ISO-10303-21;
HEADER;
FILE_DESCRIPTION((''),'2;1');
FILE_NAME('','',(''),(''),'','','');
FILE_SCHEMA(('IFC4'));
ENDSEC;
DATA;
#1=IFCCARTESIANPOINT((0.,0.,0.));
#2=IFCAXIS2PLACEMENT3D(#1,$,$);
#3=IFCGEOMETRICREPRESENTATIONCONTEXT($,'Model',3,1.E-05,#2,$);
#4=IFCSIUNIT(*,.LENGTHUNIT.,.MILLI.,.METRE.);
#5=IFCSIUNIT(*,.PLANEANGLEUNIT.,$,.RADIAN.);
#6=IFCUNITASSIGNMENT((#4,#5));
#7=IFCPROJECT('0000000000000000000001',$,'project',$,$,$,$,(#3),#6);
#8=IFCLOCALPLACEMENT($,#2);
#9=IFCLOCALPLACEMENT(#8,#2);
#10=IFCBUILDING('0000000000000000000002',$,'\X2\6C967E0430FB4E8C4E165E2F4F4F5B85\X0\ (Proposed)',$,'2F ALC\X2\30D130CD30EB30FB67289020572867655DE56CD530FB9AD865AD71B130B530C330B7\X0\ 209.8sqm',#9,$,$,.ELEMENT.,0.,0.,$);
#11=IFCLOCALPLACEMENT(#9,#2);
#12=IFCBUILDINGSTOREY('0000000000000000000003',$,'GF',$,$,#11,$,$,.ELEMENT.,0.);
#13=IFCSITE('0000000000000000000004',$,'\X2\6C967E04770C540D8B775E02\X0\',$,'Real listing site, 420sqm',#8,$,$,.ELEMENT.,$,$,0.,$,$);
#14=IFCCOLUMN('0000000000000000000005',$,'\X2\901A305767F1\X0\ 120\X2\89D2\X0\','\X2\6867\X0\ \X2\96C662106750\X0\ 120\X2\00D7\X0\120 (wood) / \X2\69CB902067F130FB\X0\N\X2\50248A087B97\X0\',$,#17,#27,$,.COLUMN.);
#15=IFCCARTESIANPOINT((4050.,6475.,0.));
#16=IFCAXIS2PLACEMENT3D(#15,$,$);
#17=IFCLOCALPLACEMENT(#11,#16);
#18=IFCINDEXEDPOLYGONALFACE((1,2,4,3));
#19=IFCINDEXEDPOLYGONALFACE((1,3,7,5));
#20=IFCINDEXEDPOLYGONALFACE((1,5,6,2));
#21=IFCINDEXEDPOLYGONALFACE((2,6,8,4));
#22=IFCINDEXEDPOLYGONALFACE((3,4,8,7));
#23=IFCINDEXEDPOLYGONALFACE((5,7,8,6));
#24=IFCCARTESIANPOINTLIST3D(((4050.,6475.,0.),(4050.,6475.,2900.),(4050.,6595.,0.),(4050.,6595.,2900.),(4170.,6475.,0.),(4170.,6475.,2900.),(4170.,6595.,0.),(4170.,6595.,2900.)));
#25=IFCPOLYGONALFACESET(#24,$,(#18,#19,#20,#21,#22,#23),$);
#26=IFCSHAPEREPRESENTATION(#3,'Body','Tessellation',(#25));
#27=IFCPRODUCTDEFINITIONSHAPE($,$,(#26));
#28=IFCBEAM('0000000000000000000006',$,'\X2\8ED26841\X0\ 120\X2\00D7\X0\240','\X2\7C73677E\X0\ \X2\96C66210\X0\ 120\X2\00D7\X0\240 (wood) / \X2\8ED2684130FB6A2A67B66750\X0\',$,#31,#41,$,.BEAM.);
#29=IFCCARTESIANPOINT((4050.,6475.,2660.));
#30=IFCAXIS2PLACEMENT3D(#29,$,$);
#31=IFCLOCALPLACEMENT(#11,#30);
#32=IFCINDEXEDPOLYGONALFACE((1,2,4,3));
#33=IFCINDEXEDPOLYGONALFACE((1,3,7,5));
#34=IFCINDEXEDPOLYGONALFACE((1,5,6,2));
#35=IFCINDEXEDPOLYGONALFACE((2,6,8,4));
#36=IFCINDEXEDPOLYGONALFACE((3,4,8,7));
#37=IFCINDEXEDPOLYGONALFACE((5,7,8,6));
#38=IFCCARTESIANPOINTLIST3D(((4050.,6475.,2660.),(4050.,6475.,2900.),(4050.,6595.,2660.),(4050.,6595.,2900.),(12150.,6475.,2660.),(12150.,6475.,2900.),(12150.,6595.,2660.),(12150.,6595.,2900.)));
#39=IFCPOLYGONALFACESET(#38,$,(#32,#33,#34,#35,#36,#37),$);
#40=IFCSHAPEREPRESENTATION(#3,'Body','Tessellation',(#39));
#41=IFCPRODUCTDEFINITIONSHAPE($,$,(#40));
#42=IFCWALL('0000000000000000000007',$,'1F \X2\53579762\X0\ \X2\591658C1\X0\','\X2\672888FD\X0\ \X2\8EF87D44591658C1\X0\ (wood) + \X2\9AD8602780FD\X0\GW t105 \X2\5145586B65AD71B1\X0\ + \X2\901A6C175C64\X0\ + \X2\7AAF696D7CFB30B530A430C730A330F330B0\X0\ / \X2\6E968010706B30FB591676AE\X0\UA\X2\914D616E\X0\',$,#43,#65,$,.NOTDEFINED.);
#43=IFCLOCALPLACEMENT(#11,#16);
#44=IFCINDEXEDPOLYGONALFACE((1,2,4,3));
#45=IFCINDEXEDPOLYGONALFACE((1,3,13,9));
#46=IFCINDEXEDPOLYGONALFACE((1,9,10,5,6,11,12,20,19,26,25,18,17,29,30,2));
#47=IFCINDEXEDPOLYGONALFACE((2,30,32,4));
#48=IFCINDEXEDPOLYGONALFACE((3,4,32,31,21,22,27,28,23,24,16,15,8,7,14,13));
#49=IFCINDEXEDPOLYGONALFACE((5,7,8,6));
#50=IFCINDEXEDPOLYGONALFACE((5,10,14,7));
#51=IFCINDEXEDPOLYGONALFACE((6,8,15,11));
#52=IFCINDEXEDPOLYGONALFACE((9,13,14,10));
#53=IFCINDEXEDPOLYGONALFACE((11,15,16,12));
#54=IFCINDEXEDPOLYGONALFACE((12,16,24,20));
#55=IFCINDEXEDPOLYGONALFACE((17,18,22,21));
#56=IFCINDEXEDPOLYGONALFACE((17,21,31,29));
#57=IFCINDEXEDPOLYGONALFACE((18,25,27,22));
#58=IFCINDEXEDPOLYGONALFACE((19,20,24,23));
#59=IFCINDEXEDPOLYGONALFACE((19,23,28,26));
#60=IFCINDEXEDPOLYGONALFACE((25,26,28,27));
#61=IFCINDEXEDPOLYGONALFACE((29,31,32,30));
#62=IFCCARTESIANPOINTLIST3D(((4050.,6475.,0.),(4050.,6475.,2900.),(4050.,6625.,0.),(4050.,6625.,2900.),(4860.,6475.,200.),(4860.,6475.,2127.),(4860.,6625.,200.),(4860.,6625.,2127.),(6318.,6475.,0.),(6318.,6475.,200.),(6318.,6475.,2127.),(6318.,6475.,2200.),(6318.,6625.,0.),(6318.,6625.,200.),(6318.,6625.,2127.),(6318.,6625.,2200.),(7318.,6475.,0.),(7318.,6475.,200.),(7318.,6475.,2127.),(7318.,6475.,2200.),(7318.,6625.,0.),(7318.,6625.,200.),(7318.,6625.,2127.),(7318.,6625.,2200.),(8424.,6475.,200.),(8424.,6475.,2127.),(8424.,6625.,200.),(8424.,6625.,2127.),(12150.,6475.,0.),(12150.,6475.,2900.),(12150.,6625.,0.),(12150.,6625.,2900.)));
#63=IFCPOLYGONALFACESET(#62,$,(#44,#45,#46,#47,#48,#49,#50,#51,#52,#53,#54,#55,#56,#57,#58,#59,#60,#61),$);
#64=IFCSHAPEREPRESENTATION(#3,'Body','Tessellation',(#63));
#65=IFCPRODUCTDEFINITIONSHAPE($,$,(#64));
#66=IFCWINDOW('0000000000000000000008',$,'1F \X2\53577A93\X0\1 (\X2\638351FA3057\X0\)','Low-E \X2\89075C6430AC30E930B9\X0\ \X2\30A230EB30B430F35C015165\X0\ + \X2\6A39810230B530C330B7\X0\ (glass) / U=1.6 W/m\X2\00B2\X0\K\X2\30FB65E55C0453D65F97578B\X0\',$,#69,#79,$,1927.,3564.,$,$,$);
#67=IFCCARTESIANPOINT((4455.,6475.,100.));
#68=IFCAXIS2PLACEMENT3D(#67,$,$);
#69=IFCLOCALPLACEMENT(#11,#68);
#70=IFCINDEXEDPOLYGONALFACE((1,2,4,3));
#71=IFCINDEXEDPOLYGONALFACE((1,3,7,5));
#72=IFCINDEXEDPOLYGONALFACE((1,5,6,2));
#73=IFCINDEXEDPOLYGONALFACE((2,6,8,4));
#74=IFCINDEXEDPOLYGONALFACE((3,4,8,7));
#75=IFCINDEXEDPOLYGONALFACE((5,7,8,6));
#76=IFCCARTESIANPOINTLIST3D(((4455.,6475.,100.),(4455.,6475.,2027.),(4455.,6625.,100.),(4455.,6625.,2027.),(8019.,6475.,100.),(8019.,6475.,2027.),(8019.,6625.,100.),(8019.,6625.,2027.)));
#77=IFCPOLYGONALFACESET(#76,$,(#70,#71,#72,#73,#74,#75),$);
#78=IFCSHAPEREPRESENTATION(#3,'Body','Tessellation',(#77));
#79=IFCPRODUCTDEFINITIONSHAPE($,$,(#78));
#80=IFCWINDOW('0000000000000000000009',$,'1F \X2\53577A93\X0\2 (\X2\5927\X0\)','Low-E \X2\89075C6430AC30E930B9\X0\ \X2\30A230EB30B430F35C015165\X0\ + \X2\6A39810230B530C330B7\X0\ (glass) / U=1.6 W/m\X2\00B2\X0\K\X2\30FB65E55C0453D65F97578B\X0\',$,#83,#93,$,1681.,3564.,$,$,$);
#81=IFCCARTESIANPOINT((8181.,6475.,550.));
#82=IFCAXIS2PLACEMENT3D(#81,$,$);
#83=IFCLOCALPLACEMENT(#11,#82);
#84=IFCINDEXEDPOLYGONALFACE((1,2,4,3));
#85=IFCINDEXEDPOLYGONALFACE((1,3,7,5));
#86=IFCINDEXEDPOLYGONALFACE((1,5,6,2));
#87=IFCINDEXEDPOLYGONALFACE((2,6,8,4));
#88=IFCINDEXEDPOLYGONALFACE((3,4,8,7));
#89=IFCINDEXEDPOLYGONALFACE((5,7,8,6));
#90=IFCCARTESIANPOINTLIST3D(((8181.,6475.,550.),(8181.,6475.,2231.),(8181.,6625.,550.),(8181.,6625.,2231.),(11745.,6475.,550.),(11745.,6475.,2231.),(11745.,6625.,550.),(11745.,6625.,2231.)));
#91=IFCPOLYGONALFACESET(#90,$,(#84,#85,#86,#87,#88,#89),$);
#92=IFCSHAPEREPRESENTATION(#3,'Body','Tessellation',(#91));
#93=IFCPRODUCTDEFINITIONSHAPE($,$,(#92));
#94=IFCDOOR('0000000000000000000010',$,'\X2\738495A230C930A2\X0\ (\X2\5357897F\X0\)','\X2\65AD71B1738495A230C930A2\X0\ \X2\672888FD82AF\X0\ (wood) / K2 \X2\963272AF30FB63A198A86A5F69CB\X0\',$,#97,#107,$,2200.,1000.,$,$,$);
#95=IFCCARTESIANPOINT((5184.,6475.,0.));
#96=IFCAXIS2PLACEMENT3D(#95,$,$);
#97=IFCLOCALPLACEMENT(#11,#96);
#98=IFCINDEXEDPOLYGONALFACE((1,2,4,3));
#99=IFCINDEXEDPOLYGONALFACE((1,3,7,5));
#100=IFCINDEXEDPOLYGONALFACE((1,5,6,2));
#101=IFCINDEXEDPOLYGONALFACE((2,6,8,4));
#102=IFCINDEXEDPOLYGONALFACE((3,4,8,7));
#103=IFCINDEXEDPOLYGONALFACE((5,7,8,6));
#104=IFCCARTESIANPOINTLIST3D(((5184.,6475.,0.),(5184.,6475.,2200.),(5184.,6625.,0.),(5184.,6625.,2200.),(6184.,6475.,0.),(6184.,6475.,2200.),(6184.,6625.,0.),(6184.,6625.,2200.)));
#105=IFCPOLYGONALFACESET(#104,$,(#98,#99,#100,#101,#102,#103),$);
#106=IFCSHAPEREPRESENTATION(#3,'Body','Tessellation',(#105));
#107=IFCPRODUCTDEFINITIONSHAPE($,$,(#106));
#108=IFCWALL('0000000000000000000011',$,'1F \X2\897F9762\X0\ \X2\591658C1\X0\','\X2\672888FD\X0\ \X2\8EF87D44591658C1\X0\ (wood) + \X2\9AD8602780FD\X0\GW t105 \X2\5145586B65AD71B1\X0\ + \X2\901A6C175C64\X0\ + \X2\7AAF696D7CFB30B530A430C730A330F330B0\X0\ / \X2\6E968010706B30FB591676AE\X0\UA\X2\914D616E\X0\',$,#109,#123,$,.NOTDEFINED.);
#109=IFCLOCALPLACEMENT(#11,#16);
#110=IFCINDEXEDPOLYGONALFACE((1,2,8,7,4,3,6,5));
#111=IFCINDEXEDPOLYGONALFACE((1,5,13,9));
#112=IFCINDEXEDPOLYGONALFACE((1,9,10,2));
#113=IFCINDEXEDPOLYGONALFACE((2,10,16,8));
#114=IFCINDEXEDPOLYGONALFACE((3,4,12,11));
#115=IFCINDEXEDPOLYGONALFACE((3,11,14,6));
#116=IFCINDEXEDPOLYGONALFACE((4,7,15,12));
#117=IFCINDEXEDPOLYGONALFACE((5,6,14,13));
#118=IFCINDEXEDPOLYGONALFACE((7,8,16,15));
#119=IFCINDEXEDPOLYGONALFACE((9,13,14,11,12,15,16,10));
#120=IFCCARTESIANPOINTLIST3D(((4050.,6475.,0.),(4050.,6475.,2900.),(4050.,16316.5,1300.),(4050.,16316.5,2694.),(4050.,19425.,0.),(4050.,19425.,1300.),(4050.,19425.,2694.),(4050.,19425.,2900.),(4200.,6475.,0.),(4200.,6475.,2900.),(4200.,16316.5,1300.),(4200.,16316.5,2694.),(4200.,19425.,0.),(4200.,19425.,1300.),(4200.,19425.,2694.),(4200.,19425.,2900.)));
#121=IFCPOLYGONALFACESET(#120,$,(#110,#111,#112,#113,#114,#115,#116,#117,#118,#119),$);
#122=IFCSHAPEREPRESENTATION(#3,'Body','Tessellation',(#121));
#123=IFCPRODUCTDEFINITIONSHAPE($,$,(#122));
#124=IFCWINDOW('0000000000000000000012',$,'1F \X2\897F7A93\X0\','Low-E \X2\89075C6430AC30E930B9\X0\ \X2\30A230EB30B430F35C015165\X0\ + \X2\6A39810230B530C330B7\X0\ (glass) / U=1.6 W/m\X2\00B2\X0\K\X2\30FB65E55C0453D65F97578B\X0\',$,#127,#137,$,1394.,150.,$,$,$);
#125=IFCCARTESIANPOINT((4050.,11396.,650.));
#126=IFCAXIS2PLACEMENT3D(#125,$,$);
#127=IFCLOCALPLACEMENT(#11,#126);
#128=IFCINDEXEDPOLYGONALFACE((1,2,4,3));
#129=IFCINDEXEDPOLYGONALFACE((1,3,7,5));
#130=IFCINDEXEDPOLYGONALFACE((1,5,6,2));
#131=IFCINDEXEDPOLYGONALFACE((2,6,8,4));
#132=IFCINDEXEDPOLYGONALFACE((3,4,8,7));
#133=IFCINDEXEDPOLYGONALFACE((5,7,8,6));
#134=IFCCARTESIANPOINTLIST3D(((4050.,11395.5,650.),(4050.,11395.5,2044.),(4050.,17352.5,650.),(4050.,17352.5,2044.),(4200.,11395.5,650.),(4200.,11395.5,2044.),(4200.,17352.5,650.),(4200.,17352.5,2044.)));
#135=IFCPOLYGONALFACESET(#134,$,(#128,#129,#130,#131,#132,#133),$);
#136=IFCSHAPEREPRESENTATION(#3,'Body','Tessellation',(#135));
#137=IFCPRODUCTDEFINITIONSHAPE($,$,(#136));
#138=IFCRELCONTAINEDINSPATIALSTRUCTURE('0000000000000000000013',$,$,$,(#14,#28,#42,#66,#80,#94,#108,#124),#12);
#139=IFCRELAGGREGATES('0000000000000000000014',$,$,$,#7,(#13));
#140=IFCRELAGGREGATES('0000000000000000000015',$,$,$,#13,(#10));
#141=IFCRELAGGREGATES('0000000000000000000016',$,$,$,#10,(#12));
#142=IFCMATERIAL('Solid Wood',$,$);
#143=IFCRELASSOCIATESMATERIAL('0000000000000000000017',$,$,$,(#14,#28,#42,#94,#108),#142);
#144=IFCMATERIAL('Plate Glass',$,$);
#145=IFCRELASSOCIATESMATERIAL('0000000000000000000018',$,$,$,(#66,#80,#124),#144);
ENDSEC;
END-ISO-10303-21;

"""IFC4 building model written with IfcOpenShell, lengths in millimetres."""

from ifc_helpers import new_model, si_unit, frame, frame_2d, origin, place, context, project, spatial, rectangle, extrude, material, element, fill, save


model = new_model("IFC4")

# Units and contexts
model_context = context("Model", 3, precision=1e-05, world=origin())
ifc_project = project(units=[si_unit("LENGTHUNIT", "METRE", prefix="MILLI"), si_unit("PLANEANGLEUNIT", "RADIAN")], contexts=[model_context])

# Site, building, storey
site_placement = place(None, origin())
site = spatial("IfcSite", under=ifc_project, at=site_placement, Name="沖縄県名護市", ObjectType="Real listing site, 420sqm", CompositionType="ELEMENT", RefElevation=0.0)
building_placement = place(site_placement, origin())
building = spatial("IfcBuilding", under=site, at=building_placement, Name="沖縄・二世帯住宅 (Proposed)", ObjectType="2F ALCパネル・木造在来工法・高断熱サッシ 209.8sqm", CompositionType="ELEMENT", ElevationOfRefHeight=0.0, ElevationOfTerrain=0.0)
storey_placement = place(building_placement, origin())
storey = spatial("IfcBuildingStorey", under=building, at=storey_placement, Name="GF", CompositionType="ELEMENT", Elevation=0.0)

# Column
ifc_material_1 = material(Name="Solid Wood")
column_placement = place(storey_placement, frame((4050.0, 6475.0, 0.0)))
element("IfcColumn", 1, at=column_placement, inside=storey, material=ifc_material_1, Name="通し柱 120角", Description="桧 集成材 120×120 (wood) / 構造柱・N値計算", PredefinedType="COLUMN", context=model_context, shape_type="SweptSolid", body=[
    extrude(rectangle(XDim=120.0, YDim=120.0, at=frame_2d((60.0, 60.0))), frame((4050.0, 6475.0, 0.0)), (0.0, 0.0, 1.0), 2900.0),
])

# Beam
beam_1_placement = place(storey_placement, frame((4050.0, 6475.0, 2660.0)))
element("IfcBeam", 2, at=beam_1_placement, inside=storey, material=ifc_material_1, Name="軒桁 120×240", Description="米松 集成 120×240 (wood) / 軒桁・横架材", PredefinedType="BEAM", context=model_context, shape_type="SweptSolid", body=[
    extrude(rectangle(XDim=8100.0, YDim=120.0, at=frame_2d((4050.0, 60.0))), frame((4050.0, 6475.0, 2660.0)), (0.0, 0.0, 1.0), 240.0),
])

# Wall, openings, windows, door
wall_1_placement = place(storey_placement, frame((4050.0, 6475.0, 0.0)))
wall_1 = element("IfcWall", 3, at=wall_1_placement, inside=storey, material=ifc_material_1, Name="1F 南面 外壁", Description="木製 軸組外壁 (wood) + 高性能GW t105 充填断熱 + 通気層 + 窯業系サイディング / 準耐火・外皮UA配慮", PredefinedType="NOTDEFINED", context=model_context, shape_type="SweptSolid", body=[
    extrude(rectangle(XDim=8100.0, YDim=150.0, at=frame_2d((4050.0, 75.0))), frame((4050.0, 6475.0, 0.0)), (0.0, 0.0, 1.0), 2900.0),
])
opening_1_placement = place(storey_placement, frame((4455.0, 6475.0, 100.0)))
opening_1 = element("IfcOpeningElement", 4, at=opening_1_placement, cuts=wall_1, PredefinedType="NOTDEFINED", context=model_context, shape_type="SweptSolid", body=[
    extrude(rectangle(XDim=3564.0, YDim=150.0, at=frame_2d((1782.0, 75.0))), frame((4455.0, 6475.0, 100.0)), (0.0, 0.0, 1.0), 1927.0),
])
opening_2_placement = place(storey_placement, frame((8181.0, 6475.0, 550.0)))
opening_2 = element("IfcOpeningElement", 5, at=opening_2_placement, cuts=wall_1, PredefinedType="NOTDEFINED", context=model_context, shape_type="SweptSolid", body=[
    extrude(rectangle(XDim=3564.0, YDim=150.0, at=frame_2d((1782.0, 75.0))), frame((8181.0, 6475.0, 550.0)), (0.0, 0.0, 1.0), 1681.0),
])
opening_3_placement = place(storey_placement, frame((5184.0, 6475.0, 0.0)))
opening_3 = element("IfcOpeningElement", 6, at=opening_3_placement, cuts=wall_1, PredefinedType="NOTDEFINED", context=model_context, shape_type="SweptSolid", body=[
    extrude(rectangle(XDim=1000.0, YDim=150.0, at=frame_2d((500.0, 75.0))), frame((5184.0, 6475.0, 0.0)), (0.0, 0.0, 1.0), 2200.0),
])
ifc_material_2 = material(Name="Plate Glass")
window_1_placement = place(storey_placement, frame((4455.0, 6475.0, 100.0)))
window_1 = element("IfcWindow", 7, at=window_1_placement, inside=storey, material=ifc_material_2, Name="1F 南窓1 (掃出し)", Description="Low-E 複層ガラス アルゴン封入 + 樹脂サッシ (glass) / U=1.6 W/m²K・日射取得型", OverallHeight=1927.0, OverallWidth=3564.0, context=model_context, shape_type="SweptSolid", body=[
    extrude(rectangle(XDim=3564.0, YDim=150.0, at=frame_2d((1782.0, 75.0))), frame((4455.0, 6475.0, 100.0)), (0.0, 0.0, 1.0), 1927.0),
])
fill(opening_1, window_1)
window_2_placement = place(storey_placement, frame((8181.0, 6475.0, 550.0)))
window_2 = element("IfcWindow", 8, at=window_2_placement, inside=storey, material=ifc_material_2, Name="1F 南窓2 (大)", Description="Low-E 複層ガラス アルゴン封入 + 樹脂サッシ (glass) / U=1.6 W/m²K・日射取得型", OverallHeight=1681.0, OverallWidth=3564.0, context=model_context, shape_type="SweptSolid", body=[
    extrude(rectangle(XDim=3564.0, YDim=150.0, at=frame_2d((1782.0, 75.0))), frame((8181.0, 6475.0, 550.0)), (0.0, 0.0, 1.0), 1681.0),
])
fill(opening_2, window_2)
door_placement = place(storey_placement, frame((5184.0, 6475.0, 0.0)))
door = element("IfcDoor", 9, at=door_placement, inside=storey, material=ifc_material_1, Name="玄関ドア (南西)", Description="断熱玄関ドア 木製芯 (wood) / K2 防犯・採風機構", OverallHeight=2200.0, OverallWidth=1000.0, context=model_context, shape_type="SweptSolid", body=[
    extrude(rectangle(XDim=1000.0, YDim=150.0, at=frame_2d((500.0, 75.0))), frame((5184.0, 6475.0, 0.0)), (0.0, 0.0, 1.0), 2200.0),
])
fill(opening_3, door)

# Wall, opening, window
wall_2_placement = place(storey_placement, frame((4050.0, 6475.0, 0.0)))
wall_2 = element("IfcWall", 10, at=wall_2_placement, inside=storey, material=ifc_material_1, Name="1F 西面 外壁", Description="木製 軸組外壁 (wood) + 高性能GW t105 充填断熱 + 通気層 + 窯業系サイディング / 準耐火・外皮UA配慮", PredefinedType="NOTDEFINED", context=model_context, shape_type="SweptSolid", body=[
    extrude(rectangle(XDim=150.0, YDim=12950.0, at=frame_2d((75.0, 6475.0))), frame((4050.0, 6475.0, 0.0)), (0.0, 0.0, 1.0), 2900.0),
])
opening_4_placement = place(storey_placement, frame((4050.0, 11396.0, 650.0)))
opening_4 = element("IfcOpeningElement", 11, at=opening_4_placement, cuts=wall_2, PredefinedType="NOTDEFINED", context=model_context, shape_type="SweptSolid", body=[
    extrude(rectangle(XDim=150.0, YDim=5957.0, at=frame_2d((75.0, 2978.0))), frame((4050.0, 11396.0, 650.0)), (0.0, 0.0, 1.0), 1394.0),
])
window_3_placement = place(storey_placement, frame((4050.0, 11396.0, 650.0)))
window_3 = element("IfcWindow", 12, at=window_3_placement, inside=storey, material=ifc_material_2, Name="1F 西窓", Description="Low-E 複層ガラス アルゴン封入 + 樹脂サッシ (glass) / U=1.6 W/m²K・日射取得型", OverallHeight=1394.0, OverallWidth=150.0, context=model_context, shape_type="SweptSolid", body=[
    extrude(rectangle(XDim=150.0, YDim=5957.0, at=frame_2d((75.0, 2978.0))), frame((4050.0, 11396.0, 650.0)), (0.0, 0.0, 1.0), 1394.0),
])
fill(opening_4, window_3)

save(model, "model.ifc")
